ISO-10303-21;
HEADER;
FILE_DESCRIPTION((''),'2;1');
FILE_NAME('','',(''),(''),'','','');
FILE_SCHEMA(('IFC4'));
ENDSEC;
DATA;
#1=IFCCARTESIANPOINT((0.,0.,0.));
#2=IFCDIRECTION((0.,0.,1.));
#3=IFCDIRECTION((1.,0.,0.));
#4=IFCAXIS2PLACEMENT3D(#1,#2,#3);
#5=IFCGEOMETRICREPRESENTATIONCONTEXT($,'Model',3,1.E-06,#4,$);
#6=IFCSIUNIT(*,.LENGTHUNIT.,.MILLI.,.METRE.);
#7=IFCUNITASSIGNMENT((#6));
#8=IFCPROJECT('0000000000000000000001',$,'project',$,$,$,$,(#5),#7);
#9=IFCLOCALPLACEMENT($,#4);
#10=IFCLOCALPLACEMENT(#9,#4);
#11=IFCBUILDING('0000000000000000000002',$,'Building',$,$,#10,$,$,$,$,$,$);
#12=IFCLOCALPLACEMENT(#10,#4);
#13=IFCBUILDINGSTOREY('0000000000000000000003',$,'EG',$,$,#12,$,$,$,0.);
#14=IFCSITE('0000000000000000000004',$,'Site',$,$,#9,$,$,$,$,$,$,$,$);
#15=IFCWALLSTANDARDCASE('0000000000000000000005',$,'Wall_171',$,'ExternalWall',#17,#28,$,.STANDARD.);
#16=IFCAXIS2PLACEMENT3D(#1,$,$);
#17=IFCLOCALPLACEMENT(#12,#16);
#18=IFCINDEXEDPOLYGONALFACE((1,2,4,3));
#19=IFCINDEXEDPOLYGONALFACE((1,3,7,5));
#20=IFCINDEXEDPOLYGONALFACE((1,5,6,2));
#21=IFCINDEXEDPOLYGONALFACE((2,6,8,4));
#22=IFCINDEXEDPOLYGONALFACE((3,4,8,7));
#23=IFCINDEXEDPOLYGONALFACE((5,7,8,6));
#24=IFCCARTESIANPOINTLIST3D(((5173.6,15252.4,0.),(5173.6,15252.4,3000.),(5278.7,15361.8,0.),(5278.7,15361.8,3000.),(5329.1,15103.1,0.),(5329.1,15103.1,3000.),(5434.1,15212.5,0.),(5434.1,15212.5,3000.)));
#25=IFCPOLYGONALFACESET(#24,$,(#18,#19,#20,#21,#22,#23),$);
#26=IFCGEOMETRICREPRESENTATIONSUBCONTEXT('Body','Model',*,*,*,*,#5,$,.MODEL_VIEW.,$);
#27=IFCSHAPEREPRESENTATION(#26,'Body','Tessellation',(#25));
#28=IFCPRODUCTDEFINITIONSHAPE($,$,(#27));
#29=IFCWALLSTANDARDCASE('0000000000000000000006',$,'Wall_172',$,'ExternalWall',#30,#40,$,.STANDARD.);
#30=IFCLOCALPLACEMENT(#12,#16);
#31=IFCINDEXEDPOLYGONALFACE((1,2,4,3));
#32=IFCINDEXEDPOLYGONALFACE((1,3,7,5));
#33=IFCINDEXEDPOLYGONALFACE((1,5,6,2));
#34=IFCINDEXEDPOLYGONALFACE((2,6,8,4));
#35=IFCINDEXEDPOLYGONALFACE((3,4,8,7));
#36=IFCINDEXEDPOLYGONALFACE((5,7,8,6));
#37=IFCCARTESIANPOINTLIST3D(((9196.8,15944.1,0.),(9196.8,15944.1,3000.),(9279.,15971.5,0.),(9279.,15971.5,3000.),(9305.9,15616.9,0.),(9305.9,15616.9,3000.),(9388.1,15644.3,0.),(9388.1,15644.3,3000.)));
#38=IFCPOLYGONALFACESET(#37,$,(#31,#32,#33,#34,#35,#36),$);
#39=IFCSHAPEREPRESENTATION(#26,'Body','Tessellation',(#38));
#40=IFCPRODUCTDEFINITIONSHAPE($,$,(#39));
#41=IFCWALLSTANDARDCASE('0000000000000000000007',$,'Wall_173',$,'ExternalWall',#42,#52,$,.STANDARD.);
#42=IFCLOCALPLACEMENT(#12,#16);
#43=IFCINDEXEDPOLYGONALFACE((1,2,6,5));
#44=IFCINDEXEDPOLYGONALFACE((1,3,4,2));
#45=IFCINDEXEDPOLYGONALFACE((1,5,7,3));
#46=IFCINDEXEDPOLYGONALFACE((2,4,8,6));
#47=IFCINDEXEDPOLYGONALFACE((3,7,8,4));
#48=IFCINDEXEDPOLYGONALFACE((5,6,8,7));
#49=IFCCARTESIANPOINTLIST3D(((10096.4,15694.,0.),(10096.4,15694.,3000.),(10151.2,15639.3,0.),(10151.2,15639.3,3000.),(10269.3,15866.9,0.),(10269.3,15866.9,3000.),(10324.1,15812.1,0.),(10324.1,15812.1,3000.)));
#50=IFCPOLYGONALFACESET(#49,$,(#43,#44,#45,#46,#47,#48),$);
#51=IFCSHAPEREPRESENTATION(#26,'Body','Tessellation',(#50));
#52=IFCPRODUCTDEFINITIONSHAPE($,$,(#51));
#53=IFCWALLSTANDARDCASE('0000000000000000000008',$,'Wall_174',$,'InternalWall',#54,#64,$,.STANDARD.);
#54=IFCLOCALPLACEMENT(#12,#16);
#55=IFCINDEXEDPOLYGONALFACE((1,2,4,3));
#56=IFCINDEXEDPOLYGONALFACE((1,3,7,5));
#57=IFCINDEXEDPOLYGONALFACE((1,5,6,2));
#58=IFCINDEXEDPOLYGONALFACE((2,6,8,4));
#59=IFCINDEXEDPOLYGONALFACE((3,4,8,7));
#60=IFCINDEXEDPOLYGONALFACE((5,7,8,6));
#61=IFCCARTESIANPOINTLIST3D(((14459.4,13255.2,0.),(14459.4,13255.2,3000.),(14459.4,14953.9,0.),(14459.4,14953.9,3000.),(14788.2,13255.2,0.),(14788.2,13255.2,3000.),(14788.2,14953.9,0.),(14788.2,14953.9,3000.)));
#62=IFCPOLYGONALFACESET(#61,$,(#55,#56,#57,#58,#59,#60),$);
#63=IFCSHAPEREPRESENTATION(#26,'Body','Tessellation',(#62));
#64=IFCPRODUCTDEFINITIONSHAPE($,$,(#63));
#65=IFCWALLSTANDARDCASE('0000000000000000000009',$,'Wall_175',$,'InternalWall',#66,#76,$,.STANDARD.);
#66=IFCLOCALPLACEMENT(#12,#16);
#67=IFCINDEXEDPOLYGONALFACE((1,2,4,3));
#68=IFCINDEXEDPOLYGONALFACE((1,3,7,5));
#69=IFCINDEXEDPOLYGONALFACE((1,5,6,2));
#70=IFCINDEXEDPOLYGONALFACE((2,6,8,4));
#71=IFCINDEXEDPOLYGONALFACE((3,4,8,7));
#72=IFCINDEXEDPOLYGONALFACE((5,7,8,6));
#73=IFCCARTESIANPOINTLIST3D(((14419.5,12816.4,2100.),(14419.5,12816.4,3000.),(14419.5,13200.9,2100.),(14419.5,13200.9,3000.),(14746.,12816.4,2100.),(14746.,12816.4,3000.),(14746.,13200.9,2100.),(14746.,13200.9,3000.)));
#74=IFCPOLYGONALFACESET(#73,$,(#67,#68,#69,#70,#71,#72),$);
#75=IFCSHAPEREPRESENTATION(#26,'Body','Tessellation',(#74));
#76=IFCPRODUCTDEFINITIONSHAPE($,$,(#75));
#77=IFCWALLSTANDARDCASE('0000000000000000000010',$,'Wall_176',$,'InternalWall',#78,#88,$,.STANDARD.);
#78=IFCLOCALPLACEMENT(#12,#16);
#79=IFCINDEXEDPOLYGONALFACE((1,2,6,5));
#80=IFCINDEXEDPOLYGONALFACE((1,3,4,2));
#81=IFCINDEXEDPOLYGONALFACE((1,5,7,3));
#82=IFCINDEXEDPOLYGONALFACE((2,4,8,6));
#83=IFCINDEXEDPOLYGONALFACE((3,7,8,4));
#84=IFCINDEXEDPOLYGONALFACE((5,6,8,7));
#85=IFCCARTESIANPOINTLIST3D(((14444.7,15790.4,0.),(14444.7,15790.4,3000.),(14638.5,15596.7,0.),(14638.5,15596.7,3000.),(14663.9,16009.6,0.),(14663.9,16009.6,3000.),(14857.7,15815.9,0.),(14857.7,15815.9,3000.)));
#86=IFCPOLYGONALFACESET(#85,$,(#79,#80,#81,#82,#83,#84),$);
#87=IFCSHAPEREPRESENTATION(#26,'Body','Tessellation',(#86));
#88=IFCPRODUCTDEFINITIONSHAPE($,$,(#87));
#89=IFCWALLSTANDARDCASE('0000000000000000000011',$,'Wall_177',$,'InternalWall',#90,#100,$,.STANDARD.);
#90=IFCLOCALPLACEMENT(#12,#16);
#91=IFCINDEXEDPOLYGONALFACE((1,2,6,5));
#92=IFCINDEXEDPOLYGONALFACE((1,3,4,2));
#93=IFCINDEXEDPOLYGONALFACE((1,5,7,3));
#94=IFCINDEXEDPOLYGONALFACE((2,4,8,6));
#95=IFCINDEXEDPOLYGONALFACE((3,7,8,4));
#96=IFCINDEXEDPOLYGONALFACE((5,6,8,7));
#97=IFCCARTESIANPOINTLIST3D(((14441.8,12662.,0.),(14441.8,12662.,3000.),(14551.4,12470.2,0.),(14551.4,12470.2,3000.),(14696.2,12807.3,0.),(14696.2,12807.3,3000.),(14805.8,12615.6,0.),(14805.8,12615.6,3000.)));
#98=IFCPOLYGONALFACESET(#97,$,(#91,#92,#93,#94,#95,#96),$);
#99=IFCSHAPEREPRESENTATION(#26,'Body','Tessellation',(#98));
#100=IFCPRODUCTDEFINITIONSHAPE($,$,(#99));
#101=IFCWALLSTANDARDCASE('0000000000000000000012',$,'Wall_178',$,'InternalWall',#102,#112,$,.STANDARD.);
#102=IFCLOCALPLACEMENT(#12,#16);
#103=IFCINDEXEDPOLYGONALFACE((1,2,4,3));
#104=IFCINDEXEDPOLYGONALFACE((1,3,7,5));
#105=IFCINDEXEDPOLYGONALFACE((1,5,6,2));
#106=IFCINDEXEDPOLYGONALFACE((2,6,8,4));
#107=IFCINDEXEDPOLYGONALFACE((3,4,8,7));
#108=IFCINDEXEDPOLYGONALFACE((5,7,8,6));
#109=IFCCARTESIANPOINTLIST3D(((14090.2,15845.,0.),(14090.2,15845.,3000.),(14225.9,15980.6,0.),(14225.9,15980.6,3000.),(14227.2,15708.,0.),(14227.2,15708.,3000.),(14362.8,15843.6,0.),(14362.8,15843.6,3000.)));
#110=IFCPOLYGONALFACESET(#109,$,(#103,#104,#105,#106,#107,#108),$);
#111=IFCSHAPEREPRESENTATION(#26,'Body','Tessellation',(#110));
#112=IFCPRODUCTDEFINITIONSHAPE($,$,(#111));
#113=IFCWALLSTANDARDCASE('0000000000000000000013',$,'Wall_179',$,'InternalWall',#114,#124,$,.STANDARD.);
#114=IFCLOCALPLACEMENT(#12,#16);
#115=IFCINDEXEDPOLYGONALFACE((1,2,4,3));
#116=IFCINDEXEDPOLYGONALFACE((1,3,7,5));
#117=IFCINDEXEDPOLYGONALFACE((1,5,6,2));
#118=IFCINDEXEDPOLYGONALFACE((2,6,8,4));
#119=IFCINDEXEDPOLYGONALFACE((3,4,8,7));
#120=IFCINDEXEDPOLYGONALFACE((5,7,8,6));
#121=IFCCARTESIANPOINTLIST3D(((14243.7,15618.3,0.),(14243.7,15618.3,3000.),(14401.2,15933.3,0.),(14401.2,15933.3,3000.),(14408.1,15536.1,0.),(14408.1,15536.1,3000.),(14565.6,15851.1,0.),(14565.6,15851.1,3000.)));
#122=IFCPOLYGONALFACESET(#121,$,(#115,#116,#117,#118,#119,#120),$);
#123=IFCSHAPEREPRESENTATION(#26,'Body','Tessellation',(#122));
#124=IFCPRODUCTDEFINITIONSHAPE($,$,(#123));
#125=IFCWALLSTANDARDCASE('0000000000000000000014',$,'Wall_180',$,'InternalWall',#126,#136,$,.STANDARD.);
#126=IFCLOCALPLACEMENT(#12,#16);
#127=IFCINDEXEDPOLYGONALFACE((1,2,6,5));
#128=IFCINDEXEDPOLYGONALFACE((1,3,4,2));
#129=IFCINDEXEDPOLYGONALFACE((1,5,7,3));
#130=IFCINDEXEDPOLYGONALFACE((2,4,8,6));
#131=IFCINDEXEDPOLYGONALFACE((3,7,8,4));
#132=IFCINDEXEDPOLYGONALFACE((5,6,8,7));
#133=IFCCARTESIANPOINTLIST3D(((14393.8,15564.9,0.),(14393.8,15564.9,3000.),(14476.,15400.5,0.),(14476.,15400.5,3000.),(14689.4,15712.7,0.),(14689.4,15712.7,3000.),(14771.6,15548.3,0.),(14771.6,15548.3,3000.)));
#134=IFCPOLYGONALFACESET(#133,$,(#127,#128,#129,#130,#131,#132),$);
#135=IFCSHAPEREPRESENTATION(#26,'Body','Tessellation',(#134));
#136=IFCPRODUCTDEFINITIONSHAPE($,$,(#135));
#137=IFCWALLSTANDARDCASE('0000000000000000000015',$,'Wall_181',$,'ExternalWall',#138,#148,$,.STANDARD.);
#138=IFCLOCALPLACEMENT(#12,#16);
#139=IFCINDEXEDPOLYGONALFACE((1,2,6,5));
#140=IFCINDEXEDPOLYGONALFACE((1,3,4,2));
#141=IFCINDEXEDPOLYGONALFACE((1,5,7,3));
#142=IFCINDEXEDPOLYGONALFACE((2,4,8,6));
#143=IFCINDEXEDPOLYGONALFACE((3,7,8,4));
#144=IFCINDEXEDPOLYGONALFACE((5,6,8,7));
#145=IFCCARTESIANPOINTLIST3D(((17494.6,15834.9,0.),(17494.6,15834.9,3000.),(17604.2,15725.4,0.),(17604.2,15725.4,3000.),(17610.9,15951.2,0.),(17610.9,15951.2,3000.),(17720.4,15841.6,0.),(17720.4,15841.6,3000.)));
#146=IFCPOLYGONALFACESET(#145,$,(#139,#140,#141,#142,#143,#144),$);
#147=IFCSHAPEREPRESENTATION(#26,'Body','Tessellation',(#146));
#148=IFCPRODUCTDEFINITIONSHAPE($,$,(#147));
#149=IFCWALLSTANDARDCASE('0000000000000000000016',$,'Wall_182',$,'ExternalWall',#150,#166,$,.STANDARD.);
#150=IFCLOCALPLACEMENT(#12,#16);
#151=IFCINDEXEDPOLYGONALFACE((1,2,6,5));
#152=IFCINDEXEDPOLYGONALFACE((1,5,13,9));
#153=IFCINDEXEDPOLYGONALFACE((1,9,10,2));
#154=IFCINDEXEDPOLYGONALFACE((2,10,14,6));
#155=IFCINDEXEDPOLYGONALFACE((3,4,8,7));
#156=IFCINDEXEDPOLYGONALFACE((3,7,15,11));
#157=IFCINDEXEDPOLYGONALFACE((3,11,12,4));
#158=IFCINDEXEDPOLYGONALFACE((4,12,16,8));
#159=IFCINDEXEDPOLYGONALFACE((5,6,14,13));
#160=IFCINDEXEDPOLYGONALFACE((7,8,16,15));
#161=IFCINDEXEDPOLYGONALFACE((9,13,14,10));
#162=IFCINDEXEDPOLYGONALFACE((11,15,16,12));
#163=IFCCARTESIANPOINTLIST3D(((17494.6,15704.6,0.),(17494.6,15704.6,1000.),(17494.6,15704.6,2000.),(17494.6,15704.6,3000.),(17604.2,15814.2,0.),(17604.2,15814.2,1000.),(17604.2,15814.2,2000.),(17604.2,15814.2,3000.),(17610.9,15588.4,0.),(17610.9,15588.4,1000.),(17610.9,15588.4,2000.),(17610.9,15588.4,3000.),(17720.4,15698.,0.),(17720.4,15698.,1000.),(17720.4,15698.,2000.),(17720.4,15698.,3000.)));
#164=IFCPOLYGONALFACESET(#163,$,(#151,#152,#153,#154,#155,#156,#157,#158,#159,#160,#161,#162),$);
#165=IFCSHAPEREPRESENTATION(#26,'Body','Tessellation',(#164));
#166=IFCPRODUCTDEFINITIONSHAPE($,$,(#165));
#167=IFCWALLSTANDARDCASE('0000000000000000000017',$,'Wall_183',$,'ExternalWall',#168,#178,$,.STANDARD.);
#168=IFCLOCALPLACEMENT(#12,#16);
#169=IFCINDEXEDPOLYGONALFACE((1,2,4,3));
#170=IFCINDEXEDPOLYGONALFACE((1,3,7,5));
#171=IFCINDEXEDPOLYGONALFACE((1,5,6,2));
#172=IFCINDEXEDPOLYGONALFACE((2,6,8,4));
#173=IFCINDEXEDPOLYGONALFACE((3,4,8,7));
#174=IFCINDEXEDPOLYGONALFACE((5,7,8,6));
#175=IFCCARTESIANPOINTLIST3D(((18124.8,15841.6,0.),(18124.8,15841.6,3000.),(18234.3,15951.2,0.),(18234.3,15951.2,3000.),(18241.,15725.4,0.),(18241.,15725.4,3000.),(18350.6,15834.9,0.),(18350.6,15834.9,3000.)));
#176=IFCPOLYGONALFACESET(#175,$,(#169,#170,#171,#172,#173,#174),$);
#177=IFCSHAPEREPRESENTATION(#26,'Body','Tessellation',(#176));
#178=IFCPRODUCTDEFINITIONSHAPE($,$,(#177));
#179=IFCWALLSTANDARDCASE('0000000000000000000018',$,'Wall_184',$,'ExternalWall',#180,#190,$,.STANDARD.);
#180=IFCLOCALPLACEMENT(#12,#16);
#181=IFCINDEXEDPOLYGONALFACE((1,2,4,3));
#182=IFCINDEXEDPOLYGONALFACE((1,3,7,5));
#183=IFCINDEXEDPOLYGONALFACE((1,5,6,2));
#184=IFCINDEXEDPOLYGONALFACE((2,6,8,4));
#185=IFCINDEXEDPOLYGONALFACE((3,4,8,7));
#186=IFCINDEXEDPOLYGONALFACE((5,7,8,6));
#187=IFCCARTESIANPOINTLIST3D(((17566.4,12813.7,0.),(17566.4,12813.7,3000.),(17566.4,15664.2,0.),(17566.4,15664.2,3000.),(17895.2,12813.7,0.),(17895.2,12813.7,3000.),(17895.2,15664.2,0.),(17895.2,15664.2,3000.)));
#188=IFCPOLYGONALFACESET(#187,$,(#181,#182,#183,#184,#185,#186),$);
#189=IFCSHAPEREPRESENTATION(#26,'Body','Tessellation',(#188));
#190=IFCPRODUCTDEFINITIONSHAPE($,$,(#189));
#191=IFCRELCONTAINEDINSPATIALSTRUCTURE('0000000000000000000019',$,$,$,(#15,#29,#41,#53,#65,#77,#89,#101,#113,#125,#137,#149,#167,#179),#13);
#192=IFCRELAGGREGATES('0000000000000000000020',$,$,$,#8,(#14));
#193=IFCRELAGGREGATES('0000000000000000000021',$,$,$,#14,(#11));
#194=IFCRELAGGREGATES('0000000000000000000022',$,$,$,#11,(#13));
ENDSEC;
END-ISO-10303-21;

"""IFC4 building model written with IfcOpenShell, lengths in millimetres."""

from ifc_helpers import new_model, si_unit, frame, origin_with_axes, place, context, subcontext, project, spatial, rectangle, extrude, element, save


model = new_model("IFC4")

# Units and contexts
model_context = context("Model", 3, precision=1e-06, world=origin_with_axes())
body_context = subcontext(model_context, "Body", "Model", "MODEL_VIEW")
ifc_project = project(units=[si_unit("LENGTHUNIT", "METRE", prefix="MILLI")], contexts=[model_context])

# Site, building, storey
site_placement = place(None, origin_with_axes())
site = spatial("IfcSite", under=ifc_project, at=site_placement, Name="Site")
building_placement = place(site_placement, origin_with_axes())
building = spatial("IfcBuilding", under=site, at=building_placement, Name="Building")
storey_placement = place(building_placement, origin_with_axes())
storey = spatial("IfcBuildingStorey", under=building, at=storey_placement, Name="EG", Elevation=0.0)

# Walls
wall_1_placement = place(storey_placement, origin_with_axes())
element("IfcWallStandardCase", 1, at=wall_1_placement, inside=storey, Name="Wall_171", ObjectType="ExternalWall", PredefinedType="STANDARD", context=body_context, shape_type="SweptSolid", body=[
    extrude(rectangle(XDim=151.6, YDim=215.5), frame((5303.9, 15232.4, 0.0), z_axis=(0.0, 0.0, 1.0), x_axis=(-0.692587, -0.721334, 0.0)), (0.0, 0.0, 1.0), 3000.0),
])
wall_2_placement = place(storey_placement, origin_with_axes())
element("IfcWallStandardCase", 2, at=wall_2_placement, inside=storey, Name="Wall_172", ObjectType="ExternalWall", PredefinedType="STANDARD", context=body_context, shape_type="SweptSolid", body=[
    extrude(rectangle(XDim=86.6, YDim=345.0), frame((9292.5, 15794.2, 0.0), z_axis=(0.0, 0.0, 1.0), x_axis=(0.948683, 0.316228, 0.0)), (0.0, 0.0, 1.0), 3000.0),
])
wall_3_placement = place(storey_placement, origin_with_axes())
element("IfcWallStandardCase", 3, at=wall_3_placement, inside=storey, Name="Wall_173", ObjectType="ExternalWall", PredefinedType="STANDARD", context=body_context, shape_type="SweptSolid", body=[
    extrude(rectangle(XDim=77.5, YDim=244.5), frame((10210.3, 15753.1, 0.0), z_axis=(0.0, 0.0, 1.0), x_axis=(0.707107, -0.707107, 0.0)), (0.0, 0.0, 1.0), 3000.0),
])
wall_4_placement = place(storey_placement, origin_with_axes())
element("IfcWallStandardCase", 4, at=wall_4_placement, inside=storey, Name="Wall_174", ObjectType="InternalWall", PredefinedType="STANDARD", context=body_context, shape_type="SweptSolid", body=[
    extrude(rectangle(XDim=1698.6, YDim=328.8), frame((14623.8, 14104.5, 0.0), z_axis=(0.0, 0.0, 1.0), x_axis=(0.0, -1.0, 0.0)), (0.0, 0.0, 1.0), 3000.0),
])

# Wall, opening
wall_5_placement = place(storey_placement, origin_with_axes())
wall_5 = element("IfcWallStandardCase", 5, at=wall_5_placement, inside=storey, Name="Wall_175", ObjectType="InternalWall", PredefinedType="STANDARD", context=body_context, shape_type="SweptSolid", body=[
    extrude(rectangle(XDim=384.5, YDim=326.5), frame((14582.7, 13008.6, 0.0), z_axis=(0.0, 0.0, 1.0), x_axis=(0.0, -1.0, 0.0)), (0.0, 0.0, 1.0), 3000.0),
])
opening_1_placement = place(wall_5_placement, origin_with_axes())
element("IfcOpeningElement", 6, at=opening_1_placement, inside=storey, cuts=wall_5, context=body_context, shape_type="SweptSolid", body=[
    extrude(rectangle(XDim=450.0, YDim=326.5), frame((14582.7, 13008.6, 0.0), z_axis=(0.0, 0.0, 1.0), x_axis=(0.0, -1.0, 0.0)), (0.0, 0.0, 1.0), 2100.0),
])

# Walls
wall_6_placement = place(storey_placement, origin_with_axes())
element("IfcWallStandardCase", 7, at=wall_6_placement, inside=storey, Name="Wall_176", ObjectType="InternalWall", PredefinedType="STANDARD", context=body_context, shape_type="SweptSolid", body=[
    extrude(rectangle(XDim=310.0, YDim=274.0), frame((14651.2, 15803.2, 0.0), z_axis=(0.0, 0.0, 1.0), x_axis=(0.707107, 0.707107, 0.0)), (0.0, 0.0, 1.0), 3000.0),
])
wall_7_placement = place(storey_placement, origin_with_axes())
element("IfcWallStandardCase", 8, at=wall_7_placement, inside=storey, Name="Wall_177", ObjectType="InternalWall", PredefinedType="STANDARD", context=body_context, shape_type="SweptSolid", body=[
    extrude(rectangle(XDim=220.9, YDim=292.9), frame((14623.8, 12638.8, 0.0), z_axis=(0.0, 0.0, 1.0), x_axis=(0.496139, -0.868243, 0.0)), (0.0, 0.0, 1.0), 3000.0),
])
wall_8_placement = place(storey_placement, origin_with_axes())
element("IfcWallStandardCase", 9, at=wall_8_placement, inside=storey, Name="Wall_178", ObjectType="InternalWall", PredefinedType="STANDARD", context=body_context, shape_type="SweptSolid", body=[
    extrude(rectangle(XDim=193.7, YDim=191.8), frame((14226.5, 15844.3, 0.0), z_axis=(0.0, 0.0, 1.0), x_axis=(-0.707107, 0.707107, 0.0)), (0.0, 0.0, 1.0), 3000.0),
])
wall_9_placement = place(storey_placement, origin_with_axes())
element("IfcWallStandardCase", 10, at=wall_9_placement, inside=storey, Name="Wall_179", ObjectType="InternalWall", PredefinedType="STANDARD", context=body_context, shape_type="SweptSolid", body=[
    extrude(rectangle(XDim=183.8, YDim=352.2), frame((14404.6, 15734.7, 0.0), z_axis=(0.0, 0.0, 1.0), x_axis=(-0.894427, 0.447214, 0.0)), (0.0, 0.0, 1.0), 3000.0),
])
wall_10_placement = place(storey_placement, origin_with_axes())
element("IfcWallStandardCase", 11, at=wall_10_placement, inside=storey, Name="Wall_180", ObjectType="InternalWall", PredefinedType="STANDARD", context=body_context, shape_type="SweptSolid", body=[
    extrude(rectangle(XDim=183.8, YDim=330.5), frame((14582.7, 15556.6, 0.0), z_axis=(0.0, 0.0, 1.0), x_axis=(0.447214, -0.894427, 0.0)), (0.0, 0.0, 1.0), 3000.0),
])
wall_11_placement = place(storey_placement, origin_with_axes())
element("IfcWallStandardCase", 12, at=wall_11_placement, inside=storey, Name="Wall_181", ObjectType="ExternalWall", PredefinedType="STANDARD", context=body_context, shape_type="SweptSolid", body=[
    extrude(rectangle(XDim=155.0, YDim=164.4), frame((17607.5, 15838.3, 0.0), z_axis=(0.0, 0.0, 1.0), x_axis=(-0.707107, 0.707107, 0.0)), (0.0, 0.0, 1.0), 3000.0),
])

# Wall, opening
wall_12_placement = place(storey_placement, origin_with_axes())
wall_12 = element("IfcWallStandardCase", 13, at=wall_12_placement, inside=storey, Name="Wall_182", ObjectType="ExternalWall", PredefinedType="STANDARD", context=body_context, shape_type="SweptSolid", body=[
    extrude(rectangle(XDim=155.0, YDim=164.4), frame((17607.5, 15701.3, 0.0), z_axis=(0.0, 0.0, 1.0), x_axis=(-0.707107, -0.707107, 0.0)), (0.0, 0.0, 1.0), 3000.0),
])
opening_2_placement = place(wall_12_placement, origin_with_axes())
element("IfcOpeningElement", 14, at=opening_2_placement, inside=storey, cuts=wall_12, context=body_context, shape_type="SweptSolid", body=[
    extrude(rectangle(XDim=600.0, YDim=164.4), frame((17589.5, 15683.3, 1000.0), z_axis=(0.0, 0.0, 1.0), x_axis=(-0.707107, -0.707107, 0.0)), (0.0, 0.0, 1.0), 1000.0),
])

# Walls
wall_13_placement = place(storey_placement, origin_with_axes())
element("IfcWallStandardCase", 15, at=wall_13_placement, inside=storey, Name="Wall_183", ObjectType="ExternalWall", PredefinedType="STANDARD", context=body_context, shape_type="SweptSolid", body=[
    extrude(rectangle(XDim=155.0, YDim=164.4), frame((18237.7, 15838.3, 0.0), z_axis=(0.0, 0.0, 1.0), x_axis=(0.707107, 0.707107, 0.0)), (0.0, 0.0, 1.0), 3000.0),
])
wall_14_placement = place(storey_placement, origin_with_axes())
element("IfcWallStandardCase", 16, at=wall_14_placement, inside=storey, Name="Wall_184", ObjectType="ExternalWall", PredefinedType="STANDARD", context=body_context, shape_type="SweptSolid", body=[
    extrude(rectangle(XDim=2850.5, YDim=328.8), frame((17730.8, 14239.0, 0.0), z_axis=(0.0, 0.0, 1.0), x_axis=(0.0, -1.0, 0.0)), (0.0, 0.0, 1.0), 3000.0),
])

save(model, "model.ifc")
